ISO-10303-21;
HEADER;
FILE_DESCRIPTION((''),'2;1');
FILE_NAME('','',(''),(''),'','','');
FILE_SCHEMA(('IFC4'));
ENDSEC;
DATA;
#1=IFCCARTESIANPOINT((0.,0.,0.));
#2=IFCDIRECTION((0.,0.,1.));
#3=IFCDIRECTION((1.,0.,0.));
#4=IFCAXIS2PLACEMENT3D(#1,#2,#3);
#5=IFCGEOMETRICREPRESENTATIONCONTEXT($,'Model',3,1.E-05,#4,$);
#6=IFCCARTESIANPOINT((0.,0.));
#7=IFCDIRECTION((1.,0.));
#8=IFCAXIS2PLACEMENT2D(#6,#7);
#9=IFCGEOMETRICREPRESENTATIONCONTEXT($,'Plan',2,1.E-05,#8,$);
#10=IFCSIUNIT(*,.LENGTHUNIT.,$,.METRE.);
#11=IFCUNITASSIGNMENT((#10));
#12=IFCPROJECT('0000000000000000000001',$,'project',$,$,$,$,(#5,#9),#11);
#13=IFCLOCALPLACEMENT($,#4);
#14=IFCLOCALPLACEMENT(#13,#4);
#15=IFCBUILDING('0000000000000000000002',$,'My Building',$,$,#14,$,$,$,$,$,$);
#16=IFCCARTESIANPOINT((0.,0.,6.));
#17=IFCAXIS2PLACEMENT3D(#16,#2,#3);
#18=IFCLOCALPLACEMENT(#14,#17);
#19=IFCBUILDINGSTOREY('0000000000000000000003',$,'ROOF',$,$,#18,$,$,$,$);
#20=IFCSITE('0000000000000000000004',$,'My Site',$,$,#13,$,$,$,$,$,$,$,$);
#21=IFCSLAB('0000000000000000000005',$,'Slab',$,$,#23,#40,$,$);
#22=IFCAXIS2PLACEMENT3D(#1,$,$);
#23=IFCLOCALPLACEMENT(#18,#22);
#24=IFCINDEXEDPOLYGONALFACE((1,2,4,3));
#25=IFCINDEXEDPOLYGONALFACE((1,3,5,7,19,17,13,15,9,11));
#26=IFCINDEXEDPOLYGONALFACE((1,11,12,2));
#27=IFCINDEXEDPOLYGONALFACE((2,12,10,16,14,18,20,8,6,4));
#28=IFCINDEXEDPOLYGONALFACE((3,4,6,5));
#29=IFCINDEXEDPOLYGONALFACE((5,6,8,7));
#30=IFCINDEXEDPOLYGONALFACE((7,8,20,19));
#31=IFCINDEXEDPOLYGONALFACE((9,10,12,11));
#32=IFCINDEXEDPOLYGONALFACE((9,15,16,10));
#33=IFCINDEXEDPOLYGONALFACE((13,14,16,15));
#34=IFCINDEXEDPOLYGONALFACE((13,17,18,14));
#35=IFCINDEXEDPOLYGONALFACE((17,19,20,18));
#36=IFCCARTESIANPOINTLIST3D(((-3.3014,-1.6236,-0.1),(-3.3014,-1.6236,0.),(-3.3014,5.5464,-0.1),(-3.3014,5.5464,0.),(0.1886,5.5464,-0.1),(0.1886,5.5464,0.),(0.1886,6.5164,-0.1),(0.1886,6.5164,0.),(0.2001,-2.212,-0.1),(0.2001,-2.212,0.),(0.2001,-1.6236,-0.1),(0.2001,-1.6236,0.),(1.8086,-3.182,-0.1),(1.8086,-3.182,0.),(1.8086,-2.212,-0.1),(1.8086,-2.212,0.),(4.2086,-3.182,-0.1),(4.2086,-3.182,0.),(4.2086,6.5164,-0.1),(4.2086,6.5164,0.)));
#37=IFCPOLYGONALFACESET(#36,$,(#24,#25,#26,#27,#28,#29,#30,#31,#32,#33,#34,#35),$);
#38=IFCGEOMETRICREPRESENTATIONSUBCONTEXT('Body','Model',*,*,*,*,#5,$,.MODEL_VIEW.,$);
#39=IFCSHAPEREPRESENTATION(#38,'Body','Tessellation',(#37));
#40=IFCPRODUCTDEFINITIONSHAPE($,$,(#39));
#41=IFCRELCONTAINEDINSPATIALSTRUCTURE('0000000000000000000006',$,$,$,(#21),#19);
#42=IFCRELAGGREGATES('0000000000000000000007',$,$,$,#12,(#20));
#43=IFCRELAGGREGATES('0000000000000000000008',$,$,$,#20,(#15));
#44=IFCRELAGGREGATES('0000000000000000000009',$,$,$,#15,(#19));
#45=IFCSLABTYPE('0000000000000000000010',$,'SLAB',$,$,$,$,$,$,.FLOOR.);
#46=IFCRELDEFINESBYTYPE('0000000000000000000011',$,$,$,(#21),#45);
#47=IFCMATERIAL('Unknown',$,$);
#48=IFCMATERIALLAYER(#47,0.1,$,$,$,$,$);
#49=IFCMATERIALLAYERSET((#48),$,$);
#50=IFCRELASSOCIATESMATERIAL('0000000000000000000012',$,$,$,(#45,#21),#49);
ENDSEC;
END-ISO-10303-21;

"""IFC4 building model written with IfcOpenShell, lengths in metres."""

from ifc_helpers import new_model, si_unit, frame, origin_with_axes, origin_2d_with_axis, place, context, subcontext, project, spatial, indexed_curve, outline, extrude, material, layer, layer_set, layer_usage, type_object, element, save


model = new_model("IFC4")

# Units and contexts
model_context = context("Model", 3, precision=1e-05, world=origin_with_axes())
plan_context = context("Plan", 2, precision=1e-05, world=origin_2d_with_axis())
body_context = subcontext(model_context, "Body", "Model", "MODEL_VIEW")
ifc_project = project(units=[si_unit("LENGTHUNIT", "METRE")], contexts=[model_context, plan_context])

# Site, building, storey
site_placement = place(None, origin_with_axes())
site = spatial("IfcSite", under=ifc_project, at=site_placement, Name="My Site")
building_placement = place(site_placement, origin_with_axes())
building = spatial("IfcBuilding", under=site, at=building_placement, Name="My Building")
storey_placement = place(building_placement, frame((0.0, 0.0, 6.0), z_axis=(0.0, 0.0, 1.0), x_axis=(1.0, 0.0, 0.0)))
storey = spatial("IfcBuildingStorey", under=building, at=storey_placement, Name="ROOF")

# Slab
ifc_material = material(Name="Unknown")
ifc_layer = layer(ifc_material, 0.1)
ifc_layer_set = layer_set([ifc_layer])
ifc_layer_usage = layer_usage(ifc_layer_set, "AXIS3", "POSITIVE", -0.1)
slab_type = type_object("IfcSlabType", Name="SLAB", PredefinedType="FLOOR", material=ifc_layer_set)
slab_placement = place(storey_placement, frame((0.1886, 6.5164, 0.0), z_axis=(0.0, 0.0, 1.0), x_axis=(1.0, 0.0, 0.0)))
element("IfcSlab", 1, at=slab_placement, inside=storey, type_object=slab_type, material=ifc_layer_usage, Name="Slab", context=body_context, shape_type="SweptSolid", body=[
    extrude(outline(indexed_curve([(0.0, 0.0), (4.02, 0.0), (4.02, -9.6984), (1.62, -9.6984), (1.62, -8.7284), (0.0115, -8.7284), (0.0115, -8.14), (-3.49, -8.14), (-3.49, -0.97), (0.0, -0.97), (0.0, 0.0)])), frame((0.0, 0.0, -0.1), z_axis=(0.0, 0.0, 1.0), x_axis=(1.0, 0.0, 0.0)), (0.0, 0.0, 1.0), 0.1),
])

save(model, "model.ifc")
